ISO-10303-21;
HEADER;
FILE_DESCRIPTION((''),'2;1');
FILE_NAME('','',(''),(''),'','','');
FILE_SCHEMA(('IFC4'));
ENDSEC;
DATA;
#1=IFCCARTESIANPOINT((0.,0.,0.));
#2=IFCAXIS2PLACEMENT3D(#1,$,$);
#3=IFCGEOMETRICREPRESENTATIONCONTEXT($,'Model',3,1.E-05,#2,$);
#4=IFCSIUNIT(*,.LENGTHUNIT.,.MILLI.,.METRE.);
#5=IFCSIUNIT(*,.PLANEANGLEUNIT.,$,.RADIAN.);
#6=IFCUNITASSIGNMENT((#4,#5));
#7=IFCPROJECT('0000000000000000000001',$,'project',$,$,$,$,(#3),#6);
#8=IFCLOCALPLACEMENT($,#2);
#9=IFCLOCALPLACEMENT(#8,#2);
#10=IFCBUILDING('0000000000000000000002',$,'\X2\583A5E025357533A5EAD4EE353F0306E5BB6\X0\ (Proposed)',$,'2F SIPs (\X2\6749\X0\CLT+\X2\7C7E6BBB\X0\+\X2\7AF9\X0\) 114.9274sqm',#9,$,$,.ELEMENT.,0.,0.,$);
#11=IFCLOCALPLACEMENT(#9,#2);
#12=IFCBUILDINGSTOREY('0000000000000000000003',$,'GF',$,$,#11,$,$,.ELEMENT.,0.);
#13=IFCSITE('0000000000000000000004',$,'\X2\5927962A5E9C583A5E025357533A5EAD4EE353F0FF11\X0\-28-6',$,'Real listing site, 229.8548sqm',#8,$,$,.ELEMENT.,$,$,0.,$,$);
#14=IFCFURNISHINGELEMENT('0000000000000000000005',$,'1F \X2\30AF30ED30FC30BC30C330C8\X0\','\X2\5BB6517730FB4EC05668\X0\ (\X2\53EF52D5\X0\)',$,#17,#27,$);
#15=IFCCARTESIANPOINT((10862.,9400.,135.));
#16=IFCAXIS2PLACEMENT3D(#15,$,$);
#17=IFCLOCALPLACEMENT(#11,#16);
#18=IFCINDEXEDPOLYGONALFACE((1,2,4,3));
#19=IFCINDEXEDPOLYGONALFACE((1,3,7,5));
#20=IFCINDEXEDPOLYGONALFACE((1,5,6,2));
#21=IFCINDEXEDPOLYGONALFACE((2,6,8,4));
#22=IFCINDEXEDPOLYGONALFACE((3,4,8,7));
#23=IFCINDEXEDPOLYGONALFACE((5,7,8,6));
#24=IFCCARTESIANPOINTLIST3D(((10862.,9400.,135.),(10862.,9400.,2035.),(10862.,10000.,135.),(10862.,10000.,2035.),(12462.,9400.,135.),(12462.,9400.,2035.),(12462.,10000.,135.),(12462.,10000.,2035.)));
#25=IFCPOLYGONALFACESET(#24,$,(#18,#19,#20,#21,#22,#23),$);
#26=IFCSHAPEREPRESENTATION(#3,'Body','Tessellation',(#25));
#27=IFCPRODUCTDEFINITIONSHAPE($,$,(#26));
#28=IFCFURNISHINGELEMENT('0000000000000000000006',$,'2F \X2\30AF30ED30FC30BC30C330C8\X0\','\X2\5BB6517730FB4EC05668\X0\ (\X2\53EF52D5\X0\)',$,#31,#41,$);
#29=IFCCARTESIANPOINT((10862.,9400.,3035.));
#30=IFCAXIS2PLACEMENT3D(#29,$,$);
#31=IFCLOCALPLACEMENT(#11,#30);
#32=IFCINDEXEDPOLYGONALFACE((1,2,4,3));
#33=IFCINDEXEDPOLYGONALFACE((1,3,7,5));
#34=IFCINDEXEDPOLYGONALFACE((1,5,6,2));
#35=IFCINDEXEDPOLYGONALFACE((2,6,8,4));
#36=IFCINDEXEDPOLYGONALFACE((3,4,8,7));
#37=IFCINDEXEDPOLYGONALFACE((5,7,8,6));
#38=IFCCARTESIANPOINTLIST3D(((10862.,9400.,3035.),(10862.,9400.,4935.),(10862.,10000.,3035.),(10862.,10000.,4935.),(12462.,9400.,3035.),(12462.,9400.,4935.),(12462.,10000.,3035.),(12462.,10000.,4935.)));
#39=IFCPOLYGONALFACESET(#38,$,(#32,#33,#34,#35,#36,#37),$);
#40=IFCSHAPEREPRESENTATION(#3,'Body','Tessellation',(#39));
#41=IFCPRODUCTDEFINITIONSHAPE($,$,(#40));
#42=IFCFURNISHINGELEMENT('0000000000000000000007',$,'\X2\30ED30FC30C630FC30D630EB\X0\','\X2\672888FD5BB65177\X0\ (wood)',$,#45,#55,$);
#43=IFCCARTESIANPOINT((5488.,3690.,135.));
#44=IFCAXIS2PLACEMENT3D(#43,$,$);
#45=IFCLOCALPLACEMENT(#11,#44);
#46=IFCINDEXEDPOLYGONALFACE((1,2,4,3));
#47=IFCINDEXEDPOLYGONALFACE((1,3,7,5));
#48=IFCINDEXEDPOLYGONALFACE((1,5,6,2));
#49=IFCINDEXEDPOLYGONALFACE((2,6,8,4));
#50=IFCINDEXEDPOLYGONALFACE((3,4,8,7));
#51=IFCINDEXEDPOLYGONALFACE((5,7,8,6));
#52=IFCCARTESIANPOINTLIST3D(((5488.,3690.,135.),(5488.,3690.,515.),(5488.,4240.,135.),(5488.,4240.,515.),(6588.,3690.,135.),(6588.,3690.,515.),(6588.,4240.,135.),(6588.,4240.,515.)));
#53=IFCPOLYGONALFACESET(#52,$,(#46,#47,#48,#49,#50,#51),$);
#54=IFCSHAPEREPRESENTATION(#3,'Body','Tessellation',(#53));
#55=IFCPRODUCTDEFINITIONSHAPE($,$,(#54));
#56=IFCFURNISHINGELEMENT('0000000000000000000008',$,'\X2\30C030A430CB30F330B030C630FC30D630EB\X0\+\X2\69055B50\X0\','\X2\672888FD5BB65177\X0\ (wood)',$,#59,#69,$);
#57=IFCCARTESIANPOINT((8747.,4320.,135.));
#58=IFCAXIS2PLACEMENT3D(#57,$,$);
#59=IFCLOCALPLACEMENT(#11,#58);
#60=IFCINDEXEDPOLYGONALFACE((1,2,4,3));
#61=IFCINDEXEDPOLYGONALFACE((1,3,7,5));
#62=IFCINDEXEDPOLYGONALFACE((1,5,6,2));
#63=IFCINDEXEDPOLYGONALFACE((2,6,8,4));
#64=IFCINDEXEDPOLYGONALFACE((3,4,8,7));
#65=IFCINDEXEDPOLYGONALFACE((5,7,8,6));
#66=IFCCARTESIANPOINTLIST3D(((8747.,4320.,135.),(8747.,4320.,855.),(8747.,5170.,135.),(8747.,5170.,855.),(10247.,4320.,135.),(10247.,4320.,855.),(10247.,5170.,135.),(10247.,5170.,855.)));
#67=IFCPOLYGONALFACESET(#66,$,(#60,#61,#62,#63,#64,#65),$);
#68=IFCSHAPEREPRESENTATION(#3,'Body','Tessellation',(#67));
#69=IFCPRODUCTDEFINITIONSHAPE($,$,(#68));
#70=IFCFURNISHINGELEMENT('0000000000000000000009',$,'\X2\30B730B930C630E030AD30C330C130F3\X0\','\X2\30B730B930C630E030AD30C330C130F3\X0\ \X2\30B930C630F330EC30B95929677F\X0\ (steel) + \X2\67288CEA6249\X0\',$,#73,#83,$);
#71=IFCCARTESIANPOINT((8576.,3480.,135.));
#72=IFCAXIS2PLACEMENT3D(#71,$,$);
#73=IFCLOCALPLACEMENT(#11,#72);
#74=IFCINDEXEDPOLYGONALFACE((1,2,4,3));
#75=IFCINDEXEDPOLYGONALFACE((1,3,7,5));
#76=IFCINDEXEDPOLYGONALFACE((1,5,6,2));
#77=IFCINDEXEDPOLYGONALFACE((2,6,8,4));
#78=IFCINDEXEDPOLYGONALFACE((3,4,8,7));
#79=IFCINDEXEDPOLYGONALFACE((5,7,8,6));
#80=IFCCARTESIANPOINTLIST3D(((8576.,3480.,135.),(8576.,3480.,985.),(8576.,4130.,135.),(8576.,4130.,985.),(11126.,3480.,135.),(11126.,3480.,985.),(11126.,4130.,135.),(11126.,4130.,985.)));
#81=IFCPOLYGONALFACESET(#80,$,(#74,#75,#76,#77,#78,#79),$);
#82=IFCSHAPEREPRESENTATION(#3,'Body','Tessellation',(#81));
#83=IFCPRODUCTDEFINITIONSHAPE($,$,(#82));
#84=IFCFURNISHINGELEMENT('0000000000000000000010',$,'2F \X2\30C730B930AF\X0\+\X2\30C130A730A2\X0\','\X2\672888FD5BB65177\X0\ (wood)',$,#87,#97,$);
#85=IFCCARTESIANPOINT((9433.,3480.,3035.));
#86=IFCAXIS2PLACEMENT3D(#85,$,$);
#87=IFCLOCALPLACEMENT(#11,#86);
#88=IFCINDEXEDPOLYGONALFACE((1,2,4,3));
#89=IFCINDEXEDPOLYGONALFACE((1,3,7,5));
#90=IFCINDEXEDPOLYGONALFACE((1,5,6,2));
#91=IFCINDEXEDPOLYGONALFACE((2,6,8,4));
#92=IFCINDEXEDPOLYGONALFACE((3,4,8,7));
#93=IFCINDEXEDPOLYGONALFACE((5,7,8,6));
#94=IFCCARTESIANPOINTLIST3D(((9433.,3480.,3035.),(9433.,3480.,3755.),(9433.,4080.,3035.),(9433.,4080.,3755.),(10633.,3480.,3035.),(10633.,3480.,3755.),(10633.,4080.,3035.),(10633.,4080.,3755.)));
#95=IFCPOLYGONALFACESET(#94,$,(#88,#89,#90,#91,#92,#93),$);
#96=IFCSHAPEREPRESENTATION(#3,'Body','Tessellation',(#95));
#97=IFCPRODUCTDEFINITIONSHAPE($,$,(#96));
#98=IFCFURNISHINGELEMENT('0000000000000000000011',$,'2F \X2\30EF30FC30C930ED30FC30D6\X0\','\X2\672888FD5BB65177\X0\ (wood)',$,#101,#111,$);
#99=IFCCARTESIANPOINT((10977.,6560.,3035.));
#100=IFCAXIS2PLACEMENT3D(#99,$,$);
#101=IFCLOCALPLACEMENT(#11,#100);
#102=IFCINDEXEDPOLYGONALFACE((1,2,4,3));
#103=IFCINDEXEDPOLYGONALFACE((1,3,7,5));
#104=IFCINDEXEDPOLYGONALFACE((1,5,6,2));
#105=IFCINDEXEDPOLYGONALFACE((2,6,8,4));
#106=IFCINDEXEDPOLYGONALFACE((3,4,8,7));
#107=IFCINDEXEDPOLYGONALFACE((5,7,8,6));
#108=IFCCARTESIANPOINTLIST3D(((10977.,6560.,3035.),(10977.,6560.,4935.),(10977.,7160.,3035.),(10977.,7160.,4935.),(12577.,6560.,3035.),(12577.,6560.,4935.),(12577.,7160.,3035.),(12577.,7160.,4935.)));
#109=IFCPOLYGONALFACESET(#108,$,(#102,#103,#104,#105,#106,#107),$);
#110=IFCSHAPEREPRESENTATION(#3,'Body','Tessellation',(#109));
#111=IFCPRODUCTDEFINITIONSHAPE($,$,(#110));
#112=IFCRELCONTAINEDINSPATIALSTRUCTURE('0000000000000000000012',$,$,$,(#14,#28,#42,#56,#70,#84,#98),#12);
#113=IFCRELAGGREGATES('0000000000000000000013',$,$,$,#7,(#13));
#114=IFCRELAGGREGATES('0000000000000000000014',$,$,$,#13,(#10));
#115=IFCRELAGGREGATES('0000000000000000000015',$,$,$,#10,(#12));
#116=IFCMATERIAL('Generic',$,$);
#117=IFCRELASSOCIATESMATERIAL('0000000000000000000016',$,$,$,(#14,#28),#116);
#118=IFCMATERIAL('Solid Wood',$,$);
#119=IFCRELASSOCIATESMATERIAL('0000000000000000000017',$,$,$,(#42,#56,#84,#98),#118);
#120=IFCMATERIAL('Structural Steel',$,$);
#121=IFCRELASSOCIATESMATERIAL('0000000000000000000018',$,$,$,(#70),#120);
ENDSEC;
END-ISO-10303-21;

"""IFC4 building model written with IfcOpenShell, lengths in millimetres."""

from ifc_helpers import new_model, si_unit, frame, frame_2d, origin, place, context, project, spatial, rectangle, extrude, material, element, save


model = new_model("IFC4")

# Units and contexts
model_context = context("Model", 3, precision=1e-05, world=origin())
ifc_project = project(units=[si_unit("LENGTHUNIT", "METRE", prefix="MILLI"), si_unit("PLANEANGLEUNIT", "RADIAN")], contexts=[model_context])

# Site, building, storey
site_placement = place(None, origin())
site = spatial("IfcSite", under=ifc_project, at=site_placement, Name="大阪府堺市南区庭代台１-28-6", ObjectType="Real listing site, 229.8548sqm", CompositionType="ELEMENT", RefElevation=0.0)
building_placement = place(site_placement, origin())
building = spatial("IfcBuilding", under=site, at=building_placement, Name="堺市南区庭代台の家 (Proposed)", ObjectType="2F SIPs (杉CLT+籾殻+竹) 114.9274sqm", CompositionType="ELEMENT", ElevationOfRefHeight=0.0, ElevationOfTerrain=0.0)
storey_placement = place(building_placement, origin())
storey = spatial("IfcBuildingStorey", under=building, at=storey_placement, Name="GF", CompositionType="ELEMENT", Elevation=0.0)

# Shared definitions
ifc_material_1 = material(Name="Solid Wood")

# Shared definitions
ifc_material_2 = material(Name="Generic")

# Furnishing elements
furnishing_1_placement = place(storey_placement, frame((10862.0, 9400.0, 135.0)))
element("IfcFurnishingElement", 1, at=furnishing_1_placement, inside=storey, material=ifc_material_2, Name="1F クローゼット", Description="家具・什器 (可動)", context=model_context, shape_type="SweptSolid", body=[
    extrude(rectangle(XDim=1600.0, YDim=600.0, at=frame_2d((800.0, 300.0))), frame((10862.0, 9400.0, 135.0)), (0.0, 0.0, 1.0), 1900.0),
])
furnishing_2_placement = place(storey_placement, frame((10862.0, 9400.0, 3035.0)))
element("IfcFurnishingElement", 2, at=furnishing_2_placement, inside=storey, material=ifc_material_2, Name="2F クローゼット", Description="家具・什器 (可動)", context=model_context, shape_type="SweptSolid", body=[
    extrude(rectangle(XDim=1600.0, YDim=600.0, at=frame_2d((800.0, 300.0))), frame((10862.0, 9400.0, 3035.0)), (0.0, 0.0, 1.0), 1900.0),
])
furnishing_3_placement = place(storey_placement, frame((5488.0, 3690.0, 135.0)))
element("IfcFurnishingElement", 3, at=furnishing_3_placement, inside=storey, material=ifc_material_1, Name="ローテーブル", Description="木製家具 (wood)", context=model_context, shape_type="SweptSolid", body=[
    extrude(rectangle(XDim=1100.0, YDim=550.0, at=frame_2d((550.0, 275.0))), frame((5488.0, 3690.0, 135.0)), (0.0, 0.0, 1.0), 380.0),
])
furnishing_4_placement = place(storey_placement, frame((8747.0, 4320.0, 135.0)))
element("IfcFurnishingElement", 4, at=furnishing_4_placement, inside=storey, material=ifc_material_1, Name="ダイニングテーブル+椅子", Description="木製家具 (wood)", context=model_context, shape_type="SweptSolid", body=[
    extrude(rectangle(XDim=1500.0, YDim=850.0, at=frame_2d((750.0, 425.0))), frame((8747.0, 4320.0, 135.0)), (0.0, 0.0, 1.0), 720.0),
])
ifc_material_3 = material(Name="Structural Steel")
furnishing_5_placement = place(storey_placement, frame((8576.0, 3480.0, 135.0)))
element("IfcFurnishingElement", 5, at=furnishing_5_placement, inside=storey, material=ifc_material_3, Name="システムキッチン", Description="システムキッチン ステンレス天板 (steel) + 木質扉", context=model_context, shape_type="SweptSolid", body=[
    extrude(rectangle(XDim=2550.0, YDim=650.0, at=frame_2d((1275.0, 325.0))), frame((8576.0, 3480.0, 135.0)), (0.0, 0.0, 1.0), 850.0),
])
furnishing_6_placement = place(storey_placement, frame((9433.0, 3480.0, 3035.0)))
element("IfcFurnishingElement", 6, at=furnishing_6_placement, inside=storey, material=ifc_material_1, Name="2F デスク+チェア", Description="木製家具 (wood)", context=model_context, shape_type="SweptSolid", body=[
    extrude(rectangle(XDim=1200.0, YDim=600.0, at=frame_2d((600.0, 300.0))), frame((9433.0, 3480.0, 3035.0)), (0.0, 0.0, 1.0), 720.0),
])
furnishing_7_placement = place(storey_placement, frame((10977.0, 6560.0, 3035.0)))
element("IfcFurnishingElement", 7, at=furnishing_7_placement, inside=storey, material=ifc_material_1, Name="2F ワードローブ", Description="木製家具 (wood)", context=model_context, shape_type="SweptSolid", body=[
    extrude(rectangle(XDim=1600.0, YDim=600.0, at=frame_2d((800.0, 300.0))), frame((10977.0, 6560.0, 3035.0)), (0.0, 0.0, 1.0), 1900.0),
])

save(model, "model.ifc")
